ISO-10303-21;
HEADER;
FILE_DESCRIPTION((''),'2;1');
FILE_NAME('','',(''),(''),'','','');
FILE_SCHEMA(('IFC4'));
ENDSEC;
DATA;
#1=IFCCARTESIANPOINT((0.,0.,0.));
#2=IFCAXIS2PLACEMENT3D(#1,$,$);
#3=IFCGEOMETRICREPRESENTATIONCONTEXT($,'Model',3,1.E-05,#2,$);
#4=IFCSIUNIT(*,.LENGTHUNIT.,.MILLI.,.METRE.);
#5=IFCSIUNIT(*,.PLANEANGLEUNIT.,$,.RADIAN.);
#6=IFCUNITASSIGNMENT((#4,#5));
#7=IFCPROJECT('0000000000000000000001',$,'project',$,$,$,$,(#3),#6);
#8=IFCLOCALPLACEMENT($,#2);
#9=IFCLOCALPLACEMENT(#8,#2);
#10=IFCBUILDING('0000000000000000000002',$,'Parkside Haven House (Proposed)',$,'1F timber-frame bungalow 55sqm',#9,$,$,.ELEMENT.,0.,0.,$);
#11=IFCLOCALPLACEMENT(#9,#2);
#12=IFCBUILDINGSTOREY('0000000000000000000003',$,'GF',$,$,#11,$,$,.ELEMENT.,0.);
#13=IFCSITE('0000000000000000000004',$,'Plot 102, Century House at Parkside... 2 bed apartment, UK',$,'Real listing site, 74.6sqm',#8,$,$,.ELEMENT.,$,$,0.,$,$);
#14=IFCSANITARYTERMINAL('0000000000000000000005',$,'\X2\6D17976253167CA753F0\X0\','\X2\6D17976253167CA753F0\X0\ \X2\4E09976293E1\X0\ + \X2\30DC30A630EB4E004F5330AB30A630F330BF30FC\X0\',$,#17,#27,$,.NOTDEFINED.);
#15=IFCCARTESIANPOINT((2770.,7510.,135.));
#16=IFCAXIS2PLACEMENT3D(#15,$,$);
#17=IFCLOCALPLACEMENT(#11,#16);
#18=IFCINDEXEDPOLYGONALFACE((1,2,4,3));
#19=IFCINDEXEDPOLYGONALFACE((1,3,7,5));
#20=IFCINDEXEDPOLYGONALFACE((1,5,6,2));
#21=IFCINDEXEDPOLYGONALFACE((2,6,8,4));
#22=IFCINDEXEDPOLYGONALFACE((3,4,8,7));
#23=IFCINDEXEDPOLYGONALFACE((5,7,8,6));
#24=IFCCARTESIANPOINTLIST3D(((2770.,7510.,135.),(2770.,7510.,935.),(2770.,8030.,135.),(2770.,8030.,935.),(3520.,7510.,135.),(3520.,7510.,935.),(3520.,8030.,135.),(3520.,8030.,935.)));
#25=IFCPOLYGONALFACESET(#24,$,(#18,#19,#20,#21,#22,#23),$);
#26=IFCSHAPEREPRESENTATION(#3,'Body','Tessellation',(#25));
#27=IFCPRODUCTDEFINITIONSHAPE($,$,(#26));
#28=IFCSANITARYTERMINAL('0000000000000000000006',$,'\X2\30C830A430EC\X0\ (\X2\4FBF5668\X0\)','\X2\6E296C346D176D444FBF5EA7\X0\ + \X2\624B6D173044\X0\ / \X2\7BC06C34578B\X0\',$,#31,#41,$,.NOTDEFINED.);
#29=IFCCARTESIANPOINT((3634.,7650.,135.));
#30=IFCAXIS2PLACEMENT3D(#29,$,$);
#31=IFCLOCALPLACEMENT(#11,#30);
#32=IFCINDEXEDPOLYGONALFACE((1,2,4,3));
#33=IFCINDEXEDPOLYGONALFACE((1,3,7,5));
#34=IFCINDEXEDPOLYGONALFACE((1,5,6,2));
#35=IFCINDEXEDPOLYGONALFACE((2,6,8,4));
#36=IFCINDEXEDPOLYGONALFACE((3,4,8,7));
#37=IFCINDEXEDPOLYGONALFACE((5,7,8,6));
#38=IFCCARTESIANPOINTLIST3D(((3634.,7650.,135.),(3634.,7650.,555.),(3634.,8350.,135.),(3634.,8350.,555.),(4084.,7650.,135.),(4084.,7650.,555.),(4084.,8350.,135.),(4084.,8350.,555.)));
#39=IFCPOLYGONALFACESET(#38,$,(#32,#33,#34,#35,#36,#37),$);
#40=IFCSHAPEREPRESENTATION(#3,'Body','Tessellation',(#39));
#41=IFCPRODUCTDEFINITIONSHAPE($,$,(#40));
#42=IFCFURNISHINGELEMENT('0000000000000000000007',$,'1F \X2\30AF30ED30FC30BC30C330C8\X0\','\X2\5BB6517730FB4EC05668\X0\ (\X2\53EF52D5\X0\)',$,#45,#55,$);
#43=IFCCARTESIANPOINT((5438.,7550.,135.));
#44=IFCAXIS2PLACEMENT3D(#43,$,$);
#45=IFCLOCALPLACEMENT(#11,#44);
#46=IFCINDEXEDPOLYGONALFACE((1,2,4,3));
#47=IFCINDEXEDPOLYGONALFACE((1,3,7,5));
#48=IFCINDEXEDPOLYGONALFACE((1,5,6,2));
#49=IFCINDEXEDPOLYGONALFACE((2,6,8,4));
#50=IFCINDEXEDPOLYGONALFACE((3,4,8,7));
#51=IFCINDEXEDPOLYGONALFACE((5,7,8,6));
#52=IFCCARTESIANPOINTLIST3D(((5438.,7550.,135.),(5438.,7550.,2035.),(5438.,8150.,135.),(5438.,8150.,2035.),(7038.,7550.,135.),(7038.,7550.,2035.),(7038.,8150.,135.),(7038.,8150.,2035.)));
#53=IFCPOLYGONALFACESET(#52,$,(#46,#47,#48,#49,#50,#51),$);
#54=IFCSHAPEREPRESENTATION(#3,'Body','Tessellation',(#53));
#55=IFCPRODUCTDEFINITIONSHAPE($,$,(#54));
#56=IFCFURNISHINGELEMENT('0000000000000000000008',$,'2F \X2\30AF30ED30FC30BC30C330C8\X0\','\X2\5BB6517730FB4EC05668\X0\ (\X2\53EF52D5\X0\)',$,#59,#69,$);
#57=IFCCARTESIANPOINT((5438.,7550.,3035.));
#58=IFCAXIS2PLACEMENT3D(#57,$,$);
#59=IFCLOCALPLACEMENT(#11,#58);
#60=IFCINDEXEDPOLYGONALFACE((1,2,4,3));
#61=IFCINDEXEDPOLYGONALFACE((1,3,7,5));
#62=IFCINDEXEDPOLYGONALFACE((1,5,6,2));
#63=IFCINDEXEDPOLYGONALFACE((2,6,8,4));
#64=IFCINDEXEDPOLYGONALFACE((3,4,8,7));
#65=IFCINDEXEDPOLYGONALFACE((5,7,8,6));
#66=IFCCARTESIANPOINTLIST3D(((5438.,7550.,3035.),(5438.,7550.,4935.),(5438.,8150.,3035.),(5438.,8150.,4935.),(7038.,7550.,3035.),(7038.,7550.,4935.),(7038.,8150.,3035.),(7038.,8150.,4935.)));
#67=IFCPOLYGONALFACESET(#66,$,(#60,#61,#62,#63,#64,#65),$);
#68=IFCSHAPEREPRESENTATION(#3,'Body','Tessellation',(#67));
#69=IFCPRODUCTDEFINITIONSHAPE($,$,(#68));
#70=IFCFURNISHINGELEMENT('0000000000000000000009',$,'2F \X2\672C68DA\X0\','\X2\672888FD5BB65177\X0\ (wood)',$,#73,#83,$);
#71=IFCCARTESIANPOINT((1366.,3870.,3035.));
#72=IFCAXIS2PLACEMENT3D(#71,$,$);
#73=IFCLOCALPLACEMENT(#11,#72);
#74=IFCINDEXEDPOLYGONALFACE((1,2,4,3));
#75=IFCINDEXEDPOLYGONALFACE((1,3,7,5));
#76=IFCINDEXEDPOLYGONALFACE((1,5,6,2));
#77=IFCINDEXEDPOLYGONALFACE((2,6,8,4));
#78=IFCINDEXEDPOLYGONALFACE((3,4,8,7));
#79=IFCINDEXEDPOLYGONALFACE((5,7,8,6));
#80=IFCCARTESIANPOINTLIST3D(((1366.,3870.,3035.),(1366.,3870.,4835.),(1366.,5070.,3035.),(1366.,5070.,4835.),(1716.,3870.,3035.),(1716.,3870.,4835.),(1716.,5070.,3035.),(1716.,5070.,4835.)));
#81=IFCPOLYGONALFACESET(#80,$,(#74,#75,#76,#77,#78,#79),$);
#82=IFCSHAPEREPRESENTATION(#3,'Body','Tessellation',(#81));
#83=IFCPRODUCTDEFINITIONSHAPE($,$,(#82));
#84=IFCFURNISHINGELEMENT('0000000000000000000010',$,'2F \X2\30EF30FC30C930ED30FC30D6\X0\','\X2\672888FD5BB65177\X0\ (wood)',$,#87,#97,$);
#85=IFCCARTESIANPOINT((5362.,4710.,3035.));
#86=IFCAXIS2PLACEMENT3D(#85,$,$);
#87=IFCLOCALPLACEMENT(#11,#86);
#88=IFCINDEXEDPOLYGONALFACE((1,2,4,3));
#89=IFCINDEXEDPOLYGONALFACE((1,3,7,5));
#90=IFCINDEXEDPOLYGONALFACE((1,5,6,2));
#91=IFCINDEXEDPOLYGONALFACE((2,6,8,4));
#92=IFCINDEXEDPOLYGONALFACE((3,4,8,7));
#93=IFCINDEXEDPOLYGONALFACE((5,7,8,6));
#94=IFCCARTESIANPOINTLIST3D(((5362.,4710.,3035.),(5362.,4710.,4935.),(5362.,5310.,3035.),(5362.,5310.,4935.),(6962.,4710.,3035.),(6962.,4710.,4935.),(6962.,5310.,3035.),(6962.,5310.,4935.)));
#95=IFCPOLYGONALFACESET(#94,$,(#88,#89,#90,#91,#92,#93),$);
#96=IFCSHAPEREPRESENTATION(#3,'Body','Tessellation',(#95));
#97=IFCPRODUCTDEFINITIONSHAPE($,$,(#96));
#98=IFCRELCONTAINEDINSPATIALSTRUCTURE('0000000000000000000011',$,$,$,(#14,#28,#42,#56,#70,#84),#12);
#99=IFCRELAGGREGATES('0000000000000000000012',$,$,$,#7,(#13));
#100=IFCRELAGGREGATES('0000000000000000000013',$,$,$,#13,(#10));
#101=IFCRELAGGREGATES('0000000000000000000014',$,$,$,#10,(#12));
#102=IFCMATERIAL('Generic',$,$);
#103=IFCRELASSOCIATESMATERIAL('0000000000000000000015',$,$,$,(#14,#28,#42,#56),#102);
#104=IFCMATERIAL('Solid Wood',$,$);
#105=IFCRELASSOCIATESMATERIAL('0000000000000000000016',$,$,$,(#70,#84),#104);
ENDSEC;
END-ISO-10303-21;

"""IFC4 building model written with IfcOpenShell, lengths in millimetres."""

from ifc_helpers import new_model, si_unit, frame, frame_2d, origin, place, context, project, spatial, rectangle, extrude, material, element, save


model = new_model("IFC4")

# Units and contexts
model_context = context("Model", 3, precision=1e-05, world=origin())
ifc_project = project(units=[si_unit("LENGTHUNIT", "METRE", prefix="MILLI"), si_unit("PLANEANGLEUNIT", "RADIAN")], contexts=[model_context])

# Site, building, storey
site_placement = place(None, origin())
site = spatial("IfcSite", under=ifc_project, at=site_placement, Name="Plot 102, Century House at Parkside... 2 bed apartment, UK", ObjectType="Real listing site, 74.6sqm", CompositionType="ELEMENT", RefElevation=0.0)
building_placement = place(site_placement, origin())
building = spatial("IfcBuilding", under=site, at=building_placement, Name="Parkside Haven House (Proposed)", ObjectType="1F timber-frame bungalow 55sqm", CompositionType="ELEMENT", ElevationOfRefHeight=0.0, ElevationOfTerrain=0.0)
storey_placement = place(building_placement, origin())
storey = spatial("IfcBuildingStorey", under=building, at=storey_placement, Name="GF", CompositionType="ELEMENT", Elevation=0.0)

# Shared definitions
ifc_material_1 = material(Name="Solid Wood")

# Shared definitions
ifc_material_2 = material(Name="Generic")

# Sanitary terminals
sanitary_terminal_1_placement = place(storey_placement, frame((2770.0, 7510.0, 135.0)))
element("IfcSanitaryTerminal", 1, at=sanitary_terminal_1_placement, inside=storey, material=ifc_material_2, Name="洗面化粧台", Description="洗面化粧台 三面鏡 + ボウル一体カウンター", PredefinedType="NOTDEFINED", context=model_context, shape_type="SweptSolid", body=[
    extrude(rectangle(XDim=750.0, YDim=520.0, at=frame_2d((375.0, 260.0))), frame((2770.0, 7510.0, 135.0)), (0.0, 0.0, 1.0), 800.0),
])
sanitary_terminal_2_placement = place(storey_placement, frame((3634.0, 7650.0, 135.0)))
element("IfcSanitaryTerminal", 2, at=sanitary_terminal_2_placement, inside=storey, material=ifc_material_2, Name="トイレ (便器)", Description="温水洗浄便座 + 手洗い / 節水型", PredefinedType="NOTDEFINED", context=model_context, shape_type="SweptSolid", body=[
    extrude(rectangle(XDim=450.0, YDim=700.0, at=frame_2d((225.0, 350.0))), frame((3634.0, 7650.0, 135.0)), (0.0, 0.0, 1.0), 420.0),
])

# Furnishing elements
furnishing_1_placement = place(storey_placement, frame((5438.0, 7550.0, 135.0)))
element("IfcFurnishingElement", 3, at=furnishing_1_placement, inside=storey, material=ifc_material_2, Name="1F クローゼット", Description="家具・什器 (可動)", context=model_context, shape_type="SweptSolid", body=[
    extrude(rectangle(XDim=1600.0, YDim=600.0, at=frame_2d((800.0, 300.0))), frame((5438.0, 7550.0, 135.0)), (0.0, 0.0, 1.0), 1900.0),
])
furnishing_2_placement = place(storey_placement, frame((5438.0, 7550.0, 3035.0)))
element("IfcFurnishingElement", 4, at=furnishing_2_placement, inside=storey, material=ifc_material_2, Name="2F クローゼット", Description="家具・什器 (可動)", context=model_context, shape_type="SweptSolid", body=[
    extrude(rectangle(XDim=1600.0, YDim=600.0, at=frame_2d((800.0, 300.0))), frame((5438.0, 7550.0, 3035.0)), (0.0, 0.0, 1.0), 1900.0),
])
furnishing_3_placement = place(storey_placement, frame((1366.0, 3870.0, 3035.0)))
element("IfcFurnishingElement", 5, at=furnishing_3_placement, inside=storey, material=ifc_material_1, Name="2F 本棚", Description="木製家具 (wood)", context=model_context, shape_type="SweptSolid", body=[
    extrude(rectangle(XDim=350.0, YDim=1200.0, at=frame_2d((175.0, 600.0))), frame((1366.0, 3870.0, 3035.0)), (0.0, 0.0, 1.0), 1800.0),
])
furnishing_4_placement = place(storey_placement, frame((5362.0, 4710.0, 3035.0)))
element("IfcFurnishingElement", 6, at=furnishing_4_placement, inside=storey, material=ifc_material_1, Name="2F ワードローブ", Description="木製家具 (wood)", context=model_context, shape_type="SweptSolid", body=[
    extrude(rectangle(XDim=1600.0, YDim=600.0, at=frame_2d((800.0, 300.0))), frame((5362.0, 4710.0, 3035.0)), (0.0, 0.0, 1.0), 1900.0),
])

save(model, "model.ifc")
